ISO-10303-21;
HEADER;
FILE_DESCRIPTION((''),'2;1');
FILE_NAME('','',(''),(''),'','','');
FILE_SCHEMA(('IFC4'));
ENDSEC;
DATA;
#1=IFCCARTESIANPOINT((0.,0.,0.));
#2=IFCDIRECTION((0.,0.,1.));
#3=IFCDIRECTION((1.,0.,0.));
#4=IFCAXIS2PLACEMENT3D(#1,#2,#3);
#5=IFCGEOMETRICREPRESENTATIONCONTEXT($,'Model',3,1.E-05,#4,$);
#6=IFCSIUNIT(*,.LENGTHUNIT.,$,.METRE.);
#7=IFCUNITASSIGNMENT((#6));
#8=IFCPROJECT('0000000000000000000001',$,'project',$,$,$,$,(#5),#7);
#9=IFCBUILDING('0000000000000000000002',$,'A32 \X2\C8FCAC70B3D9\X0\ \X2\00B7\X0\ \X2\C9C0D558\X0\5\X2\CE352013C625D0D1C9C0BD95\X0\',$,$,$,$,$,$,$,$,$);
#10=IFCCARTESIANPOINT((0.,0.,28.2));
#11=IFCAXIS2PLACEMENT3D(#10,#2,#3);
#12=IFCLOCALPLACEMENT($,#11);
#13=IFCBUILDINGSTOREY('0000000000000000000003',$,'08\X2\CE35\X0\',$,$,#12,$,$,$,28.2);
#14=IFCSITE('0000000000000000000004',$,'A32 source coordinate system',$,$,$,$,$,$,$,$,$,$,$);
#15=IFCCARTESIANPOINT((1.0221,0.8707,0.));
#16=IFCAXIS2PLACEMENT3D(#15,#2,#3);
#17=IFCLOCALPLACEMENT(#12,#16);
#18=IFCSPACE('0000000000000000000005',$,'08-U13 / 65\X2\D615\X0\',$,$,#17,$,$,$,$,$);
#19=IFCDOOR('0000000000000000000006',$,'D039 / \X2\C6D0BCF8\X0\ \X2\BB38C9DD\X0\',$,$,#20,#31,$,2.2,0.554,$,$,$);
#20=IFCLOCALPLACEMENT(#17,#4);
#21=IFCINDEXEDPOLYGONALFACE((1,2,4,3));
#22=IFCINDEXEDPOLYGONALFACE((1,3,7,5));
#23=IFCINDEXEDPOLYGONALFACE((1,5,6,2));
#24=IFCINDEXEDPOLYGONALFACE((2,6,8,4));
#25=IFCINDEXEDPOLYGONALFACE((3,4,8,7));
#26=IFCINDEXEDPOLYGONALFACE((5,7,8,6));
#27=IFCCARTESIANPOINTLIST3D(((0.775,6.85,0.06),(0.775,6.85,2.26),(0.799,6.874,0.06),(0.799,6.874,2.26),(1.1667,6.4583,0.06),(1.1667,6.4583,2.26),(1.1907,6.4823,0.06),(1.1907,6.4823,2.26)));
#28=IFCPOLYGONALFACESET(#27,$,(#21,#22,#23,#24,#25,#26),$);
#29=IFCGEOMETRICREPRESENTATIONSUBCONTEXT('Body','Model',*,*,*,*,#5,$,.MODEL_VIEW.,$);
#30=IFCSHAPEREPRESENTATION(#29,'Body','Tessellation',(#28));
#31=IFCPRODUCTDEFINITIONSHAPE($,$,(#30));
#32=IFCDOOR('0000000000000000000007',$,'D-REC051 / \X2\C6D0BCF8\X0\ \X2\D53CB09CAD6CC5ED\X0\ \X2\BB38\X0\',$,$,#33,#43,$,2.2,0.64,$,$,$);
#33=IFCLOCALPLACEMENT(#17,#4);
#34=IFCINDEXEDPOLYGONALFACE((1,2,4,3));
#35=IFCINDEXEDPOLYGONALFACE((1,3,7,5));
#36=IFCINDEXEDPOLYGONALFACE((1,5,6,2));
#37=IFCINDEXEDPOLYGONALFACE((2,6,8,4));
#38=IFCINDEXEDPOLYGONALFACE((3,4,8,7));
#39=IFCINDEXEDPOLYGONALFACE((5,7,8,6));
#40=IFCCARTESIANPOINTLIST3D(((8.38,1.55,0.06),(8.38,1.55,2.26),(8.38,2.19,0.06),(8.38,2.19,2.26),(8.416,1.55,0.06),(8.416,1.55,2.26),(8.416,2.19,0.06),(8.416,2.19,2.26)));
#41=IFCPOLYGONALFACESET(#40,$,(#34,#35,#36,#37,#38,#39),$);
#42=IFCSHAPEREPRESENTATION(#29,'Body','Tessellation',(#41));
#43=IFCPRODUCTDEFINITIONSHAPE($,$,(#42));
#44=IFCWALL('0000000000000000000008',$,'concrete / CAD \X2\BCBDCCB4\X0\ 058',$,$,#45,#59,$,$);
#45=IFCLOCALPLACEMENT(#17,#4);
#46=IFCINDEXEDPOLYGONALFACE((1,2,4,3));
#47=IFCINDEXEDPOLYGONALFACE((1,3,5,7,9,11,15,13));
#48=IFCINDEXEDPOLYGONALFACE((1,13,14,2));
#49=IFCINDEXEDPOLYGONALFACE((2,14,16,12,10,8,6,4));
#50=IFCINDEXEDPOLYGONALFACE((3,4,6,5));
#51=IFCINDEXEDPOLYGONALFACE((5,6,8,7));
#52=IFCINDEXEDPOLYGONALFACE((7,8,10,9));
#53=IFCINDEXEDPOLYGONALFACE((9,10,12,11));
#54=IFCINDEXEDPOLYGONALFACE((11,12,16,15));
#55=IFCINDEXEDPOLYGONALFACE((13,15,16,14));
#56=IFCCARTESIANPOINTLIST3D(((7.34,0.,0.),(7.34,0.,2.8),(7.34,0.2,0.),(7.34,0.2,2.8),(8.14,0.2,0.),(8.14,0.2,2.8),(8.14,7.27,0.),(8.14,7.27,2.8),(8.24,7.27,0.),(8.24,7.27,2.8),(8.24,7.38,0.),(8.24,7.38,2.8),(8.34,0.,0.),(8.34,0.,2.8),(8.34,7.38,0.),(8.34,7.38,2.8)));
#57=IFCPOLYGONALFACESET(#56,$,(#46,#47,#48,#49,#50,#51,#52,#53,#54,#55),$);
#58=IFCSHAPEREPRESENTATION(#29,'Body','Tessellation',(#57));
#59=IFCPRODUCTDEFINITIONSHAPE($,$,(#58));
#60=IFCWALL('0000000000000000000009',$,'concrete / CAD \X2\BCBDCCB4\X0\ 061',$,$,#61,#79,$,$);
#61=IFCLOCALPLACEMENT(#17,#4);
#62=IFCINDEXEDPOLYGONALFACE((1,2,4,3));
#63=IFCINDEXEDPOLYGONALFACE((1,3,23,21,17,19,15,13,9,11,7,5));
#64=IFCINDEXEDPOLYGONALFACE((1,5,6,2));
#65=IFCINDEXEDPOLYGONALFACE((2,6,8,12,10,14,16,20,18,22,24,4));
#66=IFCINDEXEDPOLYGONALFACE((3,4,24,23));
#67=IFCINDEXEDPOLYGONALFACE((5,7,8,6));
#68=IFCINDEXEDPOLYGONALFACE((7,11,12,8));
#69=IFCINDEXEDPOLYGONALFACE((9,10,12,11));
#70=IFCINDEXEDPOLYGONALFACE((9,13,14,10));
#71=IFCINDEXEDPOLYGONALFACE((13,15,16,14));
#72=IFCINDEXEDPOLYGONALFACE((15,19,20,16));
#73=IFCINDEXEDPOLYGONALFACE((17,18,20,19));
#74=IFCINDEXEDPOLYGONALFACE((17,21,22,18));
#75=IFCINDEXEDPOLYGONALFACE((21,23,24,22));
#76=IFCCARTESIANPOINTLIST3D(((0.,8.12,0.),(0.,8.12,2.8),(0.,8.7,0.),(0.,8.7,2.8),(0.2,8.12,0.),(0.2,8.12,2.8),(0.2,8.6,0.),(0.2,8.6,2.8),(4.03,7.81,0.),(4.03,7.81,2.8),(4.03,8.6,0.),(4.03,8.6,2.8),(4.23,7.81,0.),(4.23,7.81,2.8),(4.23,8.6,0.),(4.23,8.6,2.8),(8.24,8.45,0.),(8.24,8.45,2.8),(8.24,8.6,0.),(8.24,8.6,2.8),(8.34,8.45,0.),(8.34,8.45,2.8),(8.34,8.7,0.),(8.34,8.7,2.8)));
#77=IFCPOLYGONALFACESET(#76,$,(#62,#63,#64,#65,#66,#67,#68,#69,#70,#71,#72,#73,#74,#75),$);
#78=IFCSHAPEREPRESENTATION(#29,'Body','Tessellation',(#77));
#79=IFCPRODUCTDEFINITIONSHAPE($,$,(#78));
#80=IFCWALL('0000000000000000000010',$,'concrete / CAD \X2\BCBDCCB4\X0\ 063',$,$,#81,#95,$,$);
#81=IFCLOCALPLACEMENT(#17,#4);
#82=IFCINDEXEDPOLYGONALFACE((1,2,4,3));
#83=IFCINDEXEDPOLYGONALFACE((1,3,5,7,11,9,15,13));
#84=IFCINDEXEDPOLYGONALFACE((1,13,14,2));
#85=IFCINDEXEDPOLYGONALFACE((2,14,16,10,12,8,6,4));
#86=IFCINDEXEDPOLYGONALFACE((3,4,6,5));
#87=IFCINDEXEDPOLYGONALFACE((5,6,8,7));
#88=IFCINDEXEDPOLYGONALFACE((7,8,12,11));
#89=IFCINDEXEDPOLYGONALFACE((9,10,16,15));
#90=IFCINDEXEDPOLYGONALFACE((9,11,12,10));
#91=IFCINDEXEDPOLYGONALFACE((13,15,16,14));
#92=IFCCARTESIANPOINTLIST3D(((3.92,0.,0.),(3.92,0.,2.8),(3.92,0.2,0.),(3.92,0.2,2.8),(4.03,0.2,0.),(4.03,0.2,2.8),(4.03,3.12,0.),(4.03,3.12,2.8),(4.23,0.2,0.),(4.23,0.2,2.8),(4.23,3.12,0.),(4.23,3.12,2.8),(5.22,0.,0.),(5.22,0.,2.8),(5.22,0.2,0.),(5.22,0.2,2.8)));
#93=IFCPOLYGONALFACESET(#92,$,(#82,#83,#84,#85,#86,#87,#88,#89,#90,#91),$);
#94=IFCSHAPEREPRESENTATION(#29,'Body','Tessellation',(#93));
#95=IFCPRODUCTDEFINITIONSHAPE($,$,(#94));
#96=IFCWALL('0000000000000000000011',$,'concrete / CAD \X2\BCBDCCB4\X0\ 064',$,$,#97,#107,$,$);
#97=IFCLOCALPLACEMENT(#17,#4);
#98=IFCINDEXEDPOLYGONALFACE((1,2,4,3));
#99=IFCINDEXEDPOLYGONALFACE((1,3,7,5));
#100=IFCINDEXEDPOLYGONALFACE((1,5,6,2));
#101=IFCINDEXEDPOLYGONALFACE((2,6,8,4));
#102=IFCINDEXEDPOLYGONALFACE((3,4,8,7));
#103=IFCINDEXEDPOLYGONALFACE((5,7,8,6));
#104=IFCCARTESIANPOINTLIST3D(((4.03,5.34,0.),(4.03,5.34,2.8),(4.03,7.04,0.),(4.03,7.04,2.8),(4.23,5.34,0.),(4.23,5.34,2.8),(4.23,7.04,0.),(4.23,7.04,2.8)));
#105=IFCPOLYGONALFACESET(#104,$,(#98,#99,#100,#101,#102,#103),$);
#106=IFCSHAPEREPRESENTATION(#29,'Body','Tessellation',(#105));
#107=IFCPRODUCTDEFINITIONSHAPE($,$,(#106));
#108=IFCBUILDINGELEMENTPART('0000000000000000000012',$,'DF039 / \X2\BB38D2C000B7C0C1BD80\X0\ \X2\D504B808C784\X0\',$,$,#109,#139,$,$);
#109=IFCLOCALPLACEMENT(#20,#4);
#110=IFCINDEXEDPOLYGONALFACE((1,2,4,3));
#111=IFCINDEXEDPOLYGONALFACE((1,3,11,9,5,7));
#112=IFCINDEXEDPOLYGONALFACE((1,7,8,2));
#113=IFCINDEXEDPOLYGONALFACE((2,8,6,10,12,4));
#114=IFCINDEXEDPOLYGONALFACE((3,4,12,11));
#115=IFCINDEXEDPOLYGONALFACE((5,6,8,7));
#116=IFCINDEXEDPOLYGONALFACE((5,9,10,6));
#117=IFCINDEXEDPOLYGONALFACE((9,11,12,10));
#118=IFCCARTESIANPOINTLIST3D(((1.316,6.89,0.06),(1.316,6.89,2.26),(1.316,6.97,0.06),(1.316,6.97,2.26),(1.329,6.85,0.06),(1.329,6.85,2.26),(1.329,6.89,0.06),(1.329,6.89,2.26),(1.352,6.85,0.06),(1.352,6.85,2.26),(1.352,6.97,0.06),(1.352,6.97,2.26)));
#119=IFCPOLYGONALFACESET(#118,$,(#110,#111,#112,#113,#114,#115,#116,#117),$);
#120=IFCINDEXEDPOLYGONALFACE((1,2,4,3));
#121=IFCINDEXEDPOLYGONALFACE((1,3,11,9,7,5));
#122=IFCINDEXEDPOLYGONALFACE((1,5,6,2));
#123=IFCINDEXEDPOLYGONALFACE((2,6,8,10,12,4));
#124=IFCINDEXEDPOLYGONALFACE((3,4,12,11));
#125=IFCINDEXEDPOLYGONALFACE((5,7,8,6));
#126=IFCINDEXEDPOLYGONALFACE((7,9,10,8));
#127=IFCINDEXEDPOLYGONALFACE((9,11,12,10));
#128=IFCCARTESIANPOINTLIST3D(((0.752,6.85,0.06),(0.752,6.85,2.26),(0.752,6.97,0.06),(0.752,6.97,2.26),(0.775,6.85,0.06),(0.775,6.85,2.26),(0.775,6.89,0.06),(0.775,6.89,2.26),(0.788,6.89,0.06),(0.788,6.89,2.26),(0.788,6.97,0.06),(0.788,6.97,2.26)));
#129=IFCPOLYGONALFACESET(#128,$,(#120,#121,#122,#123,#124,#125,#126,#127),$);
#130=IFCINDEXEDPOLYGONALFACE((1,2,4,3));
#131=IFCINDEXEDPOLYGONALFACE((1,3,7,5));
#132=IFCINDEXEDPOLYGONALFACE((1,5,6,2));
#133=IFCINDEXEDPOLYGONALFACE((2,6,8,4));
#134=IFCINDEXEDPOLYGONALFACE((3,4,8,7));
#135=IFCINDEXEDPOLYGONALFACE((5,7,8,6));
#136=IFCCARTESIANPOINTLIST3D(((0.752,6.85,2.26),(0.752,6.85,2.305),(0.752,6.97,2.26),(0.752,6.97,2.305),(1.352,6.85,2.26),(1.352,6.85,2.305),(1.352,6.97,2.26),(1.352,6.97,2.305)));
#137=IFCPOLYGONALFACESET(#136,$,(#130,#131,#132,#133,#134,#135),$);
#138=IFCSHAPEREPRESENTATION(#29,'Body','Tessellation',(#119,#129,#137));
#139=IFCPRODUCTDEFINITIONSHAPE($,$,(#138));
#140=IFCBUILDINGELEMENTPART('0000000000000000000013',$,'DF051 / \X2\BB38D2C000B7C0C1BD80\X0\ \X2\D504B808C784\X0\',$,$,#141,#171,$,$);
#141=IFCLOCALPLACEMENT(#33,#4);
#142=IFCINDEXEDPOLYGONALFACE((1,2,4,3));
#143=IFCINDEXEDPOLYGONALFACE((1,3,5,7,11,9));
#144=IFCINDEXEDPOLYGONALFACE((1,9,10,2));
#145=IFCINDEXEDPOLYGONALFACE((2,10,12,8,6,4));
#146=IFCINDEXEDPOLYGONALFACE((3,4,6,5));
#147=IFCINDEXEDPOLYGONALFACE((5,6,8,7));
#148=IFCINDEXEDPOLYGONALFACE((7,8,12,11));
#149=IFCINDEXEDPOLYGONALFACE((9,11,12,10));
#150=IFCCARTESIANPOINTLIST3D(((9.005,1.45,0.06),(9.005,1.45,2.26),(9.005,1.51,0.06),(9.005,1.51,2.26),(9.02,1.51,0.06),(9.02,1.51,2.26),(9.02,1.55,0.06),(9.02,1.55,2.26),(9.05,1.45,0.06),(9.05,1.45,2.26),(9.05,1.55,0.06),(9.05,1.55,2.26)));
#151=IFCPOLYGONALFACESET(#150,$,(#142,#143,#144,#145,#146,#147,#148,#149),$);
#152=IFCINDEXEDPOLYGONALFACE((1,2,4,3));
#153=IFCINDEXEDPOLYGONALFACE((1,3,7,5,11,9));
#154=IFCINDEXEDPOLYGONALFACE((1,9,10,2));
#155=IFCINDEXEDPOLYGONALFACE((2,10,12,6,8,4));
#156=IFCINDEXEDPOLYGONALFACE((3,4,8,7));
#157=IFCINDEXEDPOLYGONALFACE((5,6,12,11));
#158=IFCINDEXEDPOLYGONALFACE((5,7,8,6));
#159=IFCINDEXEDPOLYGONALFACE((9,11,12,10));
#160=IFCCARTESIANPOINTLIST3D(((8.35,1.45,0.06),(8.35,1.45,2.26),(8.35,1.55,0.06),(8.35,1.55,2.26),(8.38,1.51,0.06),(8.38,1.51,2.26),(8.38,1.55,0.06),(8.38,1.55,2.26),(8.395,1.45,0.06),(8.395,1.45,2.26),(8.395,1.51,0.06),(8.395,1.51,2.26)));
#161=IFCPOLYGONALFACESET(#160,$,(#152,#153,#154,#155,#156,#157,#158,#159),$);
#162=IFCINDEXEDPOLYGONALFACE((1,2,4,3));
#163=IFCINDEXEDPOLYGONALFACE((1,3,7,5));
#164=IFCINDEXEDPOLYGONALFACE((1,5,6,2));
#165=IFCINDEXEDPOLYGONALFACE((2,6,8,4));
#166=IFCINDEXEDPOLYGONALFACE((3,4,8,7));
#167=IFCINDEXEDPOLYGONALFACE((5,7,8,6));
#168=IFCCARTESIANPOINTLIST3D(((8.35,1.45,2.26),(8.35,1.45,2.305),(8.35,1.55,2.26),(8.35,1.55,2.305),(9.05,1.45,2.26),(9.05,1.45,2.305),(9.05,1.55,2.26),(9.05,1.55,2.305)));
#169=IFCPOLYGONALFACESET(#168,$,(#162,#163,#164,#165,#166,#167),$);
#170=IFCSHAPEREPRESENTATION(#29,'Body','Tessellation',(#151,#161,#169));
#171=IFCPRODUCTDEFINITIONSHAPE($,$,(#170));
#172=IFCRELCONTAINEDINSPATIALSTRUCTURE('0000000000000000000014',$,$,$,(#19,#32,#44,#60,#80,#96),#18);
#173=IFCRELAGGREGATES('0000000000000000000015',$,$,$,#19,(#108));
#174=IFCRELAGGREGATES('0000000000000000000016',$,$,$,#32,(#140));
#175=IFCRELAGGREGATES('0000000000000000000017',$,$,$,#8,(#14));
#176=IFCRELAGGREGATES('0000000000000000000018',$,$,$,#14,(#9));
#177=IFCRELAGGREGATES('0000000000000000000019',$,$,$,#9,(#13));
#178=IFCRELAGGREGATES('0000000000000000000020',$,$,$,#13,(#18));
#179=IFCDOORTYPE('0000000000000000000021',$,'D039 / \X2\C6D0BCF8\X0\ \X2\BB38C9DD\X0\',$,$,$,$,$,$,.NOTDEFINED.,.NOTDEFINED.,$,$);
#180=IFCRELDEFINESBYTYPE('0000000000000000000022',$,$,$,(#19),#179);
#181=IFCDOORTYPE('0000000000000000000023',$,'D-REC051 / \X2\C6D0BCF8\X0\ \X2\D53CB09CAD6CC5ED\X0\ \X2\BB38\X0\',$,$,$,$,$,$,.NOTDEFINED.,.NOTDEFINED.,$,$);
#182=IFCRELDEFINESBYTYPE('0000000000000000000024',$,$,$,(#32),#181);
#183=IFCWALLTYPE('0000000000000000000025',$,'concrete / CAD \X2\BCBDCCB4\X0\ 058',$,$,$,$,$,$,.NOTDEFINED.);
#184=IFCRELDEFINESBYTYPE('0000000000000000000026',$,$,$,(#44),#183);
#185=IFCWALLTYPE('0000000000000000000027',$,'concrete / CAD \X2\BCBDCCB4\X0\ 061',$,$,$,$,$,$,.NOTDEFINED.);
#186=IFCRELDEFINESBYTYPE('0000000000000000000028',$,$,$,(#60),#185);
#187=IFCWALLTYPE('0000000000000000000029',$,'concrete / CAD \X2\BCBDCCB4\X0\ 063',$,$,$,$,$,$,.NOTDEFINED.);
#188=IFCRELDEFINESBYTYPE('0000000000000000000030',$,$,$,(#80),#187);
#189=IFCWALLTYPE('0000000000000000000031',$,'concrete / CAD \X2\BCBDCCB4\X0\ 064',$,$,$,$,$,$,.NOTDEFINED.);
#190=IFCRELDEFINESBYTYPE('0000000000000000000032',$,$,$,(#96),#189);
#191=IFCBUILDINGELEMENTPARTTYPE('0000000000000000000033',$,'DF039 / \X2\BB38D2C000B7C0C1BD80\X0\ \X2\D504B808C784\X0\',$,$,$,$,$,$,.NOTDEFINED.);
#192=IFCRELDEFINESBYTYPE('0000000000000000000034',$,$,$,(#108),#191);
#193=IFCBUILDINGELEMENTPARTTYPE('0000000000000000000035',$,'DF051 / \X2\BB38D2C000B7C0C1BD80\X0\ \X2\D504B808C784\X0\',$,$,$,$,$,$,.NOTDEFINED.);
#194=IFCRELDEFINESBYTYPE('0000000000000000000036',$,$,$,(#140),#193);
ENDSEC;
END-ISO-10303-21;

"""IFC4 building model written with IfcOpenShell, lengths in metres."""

from ifc_helpers import new_model, si_unit, frame, origin, origin_with_axes, place, context, subcontext, project, spatial, polyline, outline, extrude, source, transform, mapped, type_object, type_shapes, element, aggregate, save


model = new_model("IFC4")

# Units and contexts
model_context = context("Model", 3, precision=1e-05, world=origin_with_axes())
body_context = subcontext(model_context, "Body", "Model", "MODEL_VIEW")
ifc_project = project(units=[si_unit("LENGTHUNIT", "METRE")], contexts=[model_context])

# Site, building, storey, space
storey_placement = place(None, frame((0.0, 0.0, 28.2), z_axis=(0.0, 0.0, 1.0), x_axis=(1.0, 0.0, 0.0)))
space_placement = place(storey_placement, frame((1.0221, 0.8707, 0.0), z_axis=(0.0, 0.0, 1.0), x_axis=(1.0, 0.0, 0.0)))
site = spatial("IfcSite", under=ifc_project, Name="A32 source coordinate system")
building = spatial("IfcBuilding", under=site, Name="A32 주거동 · 지하5층–옥탑지붕")
storey = spatial("IfcBuildingStorey", under=building, at=storey_placement, Name="08층", Elevation=28.2)
space = spatial("IfcSpace", under=storey, at=space_placement, Name="08-U13 / 65형")

# Doors
door_type_1 = type_object("IfcDoorType", Name="D039 / 원본 문짝", OperationType="NOTDEFINED", PredefinedType="NOTDEFINED")
shared_shape_1 = source(origin(), body_context, "Body", "SweptSolid", [
    extrude(outline(polyline([(1.1907, 6.4823), (1.1667, 6.4583), (0.775, 6.85), (0.799, 6.874), (1.1907, 6.4823)])), frame((0.0, 0.0, 0.06)), (0.0, 0.0, 1.0), 2.2),
])
type_shapes(door_type_1, [shared_shape_1])
door_1_placement = place(space_placement, origin_with_axes())
door_1 = element("IfcDoor", 1, at=door_1_placement, inside=space, type_object=door_type_1, Name="D039 / 원본 문짝", OverallHeight=2.2, OverallWidth=0.554, context=body_context, shape_type="MappedRepresentation", body=[
    mapped(shared_shape_1, transform((0.0, 0.0, 0.0), scale=1.0)),
])
door_type_2 = type_object("IfcDoorType", Name="D-REC051 / 원본 피난구역 문", OperationType="NOTDEFINED", PredefinedType="NOTDEFINED")
shared_shape_2 = source(origin(), body_context, "Body", "SweptSolid", [
    extrude(outline(polyline([(8.416, 2.19), (8.416, 1.55), (8.38, 1.55), (8.38, 2.19), (8.416, 2.19)])), frame((0.0, 0.0, 0.06)), (0.0, 0.0, 1.0), 2.2),
])
type_shapes(door_type_2, [shared_shape_2])
door_2_placement = place(space_placement, origin_with_axes())
door_2 = element("IfcDoor", 2, at=door_2_placement, inside=space, type_object=door_type_2, Name="D-REC051 / 원본 피난구역 문", OverallHeight=2.2, OverallWidth=0.64, context=body_context, shape_type="MappedRepresentation", body=[
    mapped(shared_shape_2, transform((0.0, 0.0, 0.0), scale=1.0)),
])

# Walls
wall_type_1 = type_object("IfcWallType", Name="concrete / CAD 벽체 058", PredefinedType="NOTDEFINED")
shared_shape_3 = source(origin(), body_context, "Body", "SweptSolid", [
    extrude(outline(polyline([(8.34, 0.0), (7.34, 0.0), (7.34, 0.2), (8.14, 0.2), (8.14, 7.27), (8.24, 7.27), (8.24, 7.38), (8.34, 7.38), (8.34, 0.0)])), origin(), (0.0, 0.0, 1.0), 2.8),
])
type_shapes(wall_type_1, [shared_shape_3])
wall_1_placement = place(space_placement, origin_with_axes())
element("IfcWall", 3, at=wall_1_placement, inside=space, type_object=wall_type_1, Name="concrete / CAD 벽체 058", context=body_context, shape_type="MappedRepresentation", body=[
    mapped(shared_shape_3, transform((0.0, 0.0, 0.0), scale=1.0)),
])
wall_type_2 = type_object("IfcWallType", Name="concrete / CAD 벽체 061", PredefinedType="NOTDEFINED")
shared_shape_4 = source(origin(), body_context, "Body", "SweptSolid", [
    extrude(outline(polyline([(0.2, 8.6), (0.2, 8.12), (0.0, 8.12), (0.0, 8.7), (8.34, 8.7), (8.34, 8.45), (8.24, 8.45), (8.24, 8.6), (4.23, 8.6), (4.23, 7.81), (4.03, 7.81), (4.03, 8.6), (0.2, 8.6)])), origin(), (0.0, 0.0, 1.0), 2.8),
])
type_shapes(wall_type_2, [shared_shape_4])
wall_2_placement = place(space_placement, origin_with_axes())
element("IfcWall", 4, at=wall_2_placement, inside=space, type_object=wall_type_2, Name="concrete / CAD 벽체 061", context=body_context, shape_type="MappedRepresentation", body=[
    mapped(shared_shape_4, transform((0.0, 0.0, 0.0), scale=1.0)),
])
wall_type_3 = type_object("IfcWallType", Name="concrete / CAD 벽체 063", PredefinedType="NOTDEFINED")
shared_shape_5 = source(origin(), body_context, "Body", "SweptSolid", [
    extrude(outline(polyline([(5.22, 0.0), (3.92, 0.0), (3.92, 0.2), (4.03, 0.2), (4.03, 3.12), (4.23, 3.12), (4.23, 0.2), (5.22, 0.2), (5.22, 0.0)])), origin(), (0.0, 0.0, 1.0), 2.8),
])
type_shapes(wall_type_3, [shared_shape_5])
wall_3_placement = place(space_placement, origin_with_axes())
element("IfcWall", 5, at=wall_3_placement, inside=space, type_object=wall_type_3, Name="concrete / CAD 벽체 063", context=body_context, shape_type="MappedRepresentation", body=[
    mapped(shared_shape_5, transform((0.0, 0.0, 0.0), scale=1.0)),
])
wall_type_4 = type_object("IfcWallType", Name="concrete / CAD 벽체 064", PredefinedType="NOTDEFINED")
shared_shape_6 = source(origin(), body_context, "Body", "SweptSolid", [
    extrude(outline(polyline([(4.03, 7.04), (4.23, 7.04), (4.23, 5.34), (4.03, 5.34), (4.03, 7.04)])), origin(), (0.0, 0.0, 1.0), 2.8),
])
type_shapes(wall_type_4, [shared_shape_6])
wall_4_placement = place(space_placement, origin_with_axes())
element("IfcWall", 6, at=wall_4_placement, inside=space, type_object=wall_type_4, Name="concrete / CAD 벽체 064", context=body_context, shape_type="MappedRepresentation", body=[
    mapped(shared_shape_6, transform((0.0, 0.0, 0.0), scale=1.0)),
])

# Building element parts
building_element_part_type_1 = type_object("IfcBuildingElementPartType", Name="DF039 / 문틀·상부 프레임", PredefinedType="NOTDEFINED")
shared_shape_7 = source(origin(), body_context, "Body", "SweptSolid", [
    extrude(outline(polyline([(1.352, 6.85), (1.329, 6.85), (1.329, 6.89), (1.316, 6.89), (1.316, 6.97), (1.352, 6.97), (1.352, 6.85)])), frame((0.0, 0.0, 0.06)), (0.0, 0.0, 1.0), 2.2),
    extrude(outline(polyline([(0.788, 6.97), (0.788, 6.89), (0.775, 6.89), (0.775, 6.85), (0.752, 6.85), (0.752, 6.97), (0.788, 6.97)])), frame((0.0, 0.0, 0.06)), (0.0, 0.0, 1.0), 2.2),
    extrude(outline(polyline([(0.752, 6.85), (0.752, 6.97), (1.352, 6.97), (1.352, 6.85), (0.752, 6.85)])), frame((0.0, 0.0, 2.26)), (0.0, 0.0, 1.0), 0.045),
])
type_shapes(building_element_part_type_1, [shared_shape_7])
building_element_part_1_placement = place(door_1_placement, origin_with_axes())
building_element_part_1 = element("IfcBuildingElementPart", 7, at=building_element_part_1_placement, type_object=building_element_part_type_1, Name="DF039 / 문틀·상부 프레임", context=body_context, shape_type="MappedRepresentation", body=[
    mapped(shared_shape_7, transform((0.0, 0.0, 0.0), scale=1.0)),
])
aggregate(door_1, [building_element_part_1])
building_element_part_type_2 = type_object("IfcBuildingElementPartType", Name="DF051 / 문틀·상부 프레임", PredefinedType="NOTDEFINED")
shared_shape_8 = source(origin(), body_context, "Body", "SweptSolid", [
    extrude(outline(polyline([(9.05, 1.45), (9.005, 1.45), (9.005, 1.51), (9.02, 1.51), (9.02, 1.55), (9.05, 1.55), (9.05, 1.45)])), frame((0.0, 0.0, 0.06)), (0.0, 0.0, 1.0), 2.2),
    extrude(outline(polyline([(8.38, 1.55), (8.38, 1.51), (8.395, 1.51), (8.395, 1.45), (8.35, 1.45), (8.35, 1.55), (8.38, 1.55)])), frame((0.0, 0.0, 0.06)), (0.0, 0.0, 1.0), 2.2),
    extrude(outline(polyline([(8.35, 1.45), (8.35, 1.55), (9.05, 1.55), (9.05, 1.45), (8.35, 1.45)])), frame((0.0, 0.0, 2.26)), (0.0, 0.0, 1.0), 0.045),
])
type_shapes(building_element_part_type_2, [shared_shape_8])
building_element_part_2_placement = place(door_2_placement, origin_with_axes())
building_element_part_2 = element("IfcBuildingElementPart", 8, at=building_element_part_2_placement, type_object=building_element_part_type_2, Name="DF051 / 문틀·상부 프레임", context=body_context, shape_type="MappedRepresentation", body=[
    mapped(shared_shape_8, transform((0.0, 0.0, 0.0), scale=1.0)),
])
aggregate(door_2, [building_element_part_2])

save(model, "model.ifc")
